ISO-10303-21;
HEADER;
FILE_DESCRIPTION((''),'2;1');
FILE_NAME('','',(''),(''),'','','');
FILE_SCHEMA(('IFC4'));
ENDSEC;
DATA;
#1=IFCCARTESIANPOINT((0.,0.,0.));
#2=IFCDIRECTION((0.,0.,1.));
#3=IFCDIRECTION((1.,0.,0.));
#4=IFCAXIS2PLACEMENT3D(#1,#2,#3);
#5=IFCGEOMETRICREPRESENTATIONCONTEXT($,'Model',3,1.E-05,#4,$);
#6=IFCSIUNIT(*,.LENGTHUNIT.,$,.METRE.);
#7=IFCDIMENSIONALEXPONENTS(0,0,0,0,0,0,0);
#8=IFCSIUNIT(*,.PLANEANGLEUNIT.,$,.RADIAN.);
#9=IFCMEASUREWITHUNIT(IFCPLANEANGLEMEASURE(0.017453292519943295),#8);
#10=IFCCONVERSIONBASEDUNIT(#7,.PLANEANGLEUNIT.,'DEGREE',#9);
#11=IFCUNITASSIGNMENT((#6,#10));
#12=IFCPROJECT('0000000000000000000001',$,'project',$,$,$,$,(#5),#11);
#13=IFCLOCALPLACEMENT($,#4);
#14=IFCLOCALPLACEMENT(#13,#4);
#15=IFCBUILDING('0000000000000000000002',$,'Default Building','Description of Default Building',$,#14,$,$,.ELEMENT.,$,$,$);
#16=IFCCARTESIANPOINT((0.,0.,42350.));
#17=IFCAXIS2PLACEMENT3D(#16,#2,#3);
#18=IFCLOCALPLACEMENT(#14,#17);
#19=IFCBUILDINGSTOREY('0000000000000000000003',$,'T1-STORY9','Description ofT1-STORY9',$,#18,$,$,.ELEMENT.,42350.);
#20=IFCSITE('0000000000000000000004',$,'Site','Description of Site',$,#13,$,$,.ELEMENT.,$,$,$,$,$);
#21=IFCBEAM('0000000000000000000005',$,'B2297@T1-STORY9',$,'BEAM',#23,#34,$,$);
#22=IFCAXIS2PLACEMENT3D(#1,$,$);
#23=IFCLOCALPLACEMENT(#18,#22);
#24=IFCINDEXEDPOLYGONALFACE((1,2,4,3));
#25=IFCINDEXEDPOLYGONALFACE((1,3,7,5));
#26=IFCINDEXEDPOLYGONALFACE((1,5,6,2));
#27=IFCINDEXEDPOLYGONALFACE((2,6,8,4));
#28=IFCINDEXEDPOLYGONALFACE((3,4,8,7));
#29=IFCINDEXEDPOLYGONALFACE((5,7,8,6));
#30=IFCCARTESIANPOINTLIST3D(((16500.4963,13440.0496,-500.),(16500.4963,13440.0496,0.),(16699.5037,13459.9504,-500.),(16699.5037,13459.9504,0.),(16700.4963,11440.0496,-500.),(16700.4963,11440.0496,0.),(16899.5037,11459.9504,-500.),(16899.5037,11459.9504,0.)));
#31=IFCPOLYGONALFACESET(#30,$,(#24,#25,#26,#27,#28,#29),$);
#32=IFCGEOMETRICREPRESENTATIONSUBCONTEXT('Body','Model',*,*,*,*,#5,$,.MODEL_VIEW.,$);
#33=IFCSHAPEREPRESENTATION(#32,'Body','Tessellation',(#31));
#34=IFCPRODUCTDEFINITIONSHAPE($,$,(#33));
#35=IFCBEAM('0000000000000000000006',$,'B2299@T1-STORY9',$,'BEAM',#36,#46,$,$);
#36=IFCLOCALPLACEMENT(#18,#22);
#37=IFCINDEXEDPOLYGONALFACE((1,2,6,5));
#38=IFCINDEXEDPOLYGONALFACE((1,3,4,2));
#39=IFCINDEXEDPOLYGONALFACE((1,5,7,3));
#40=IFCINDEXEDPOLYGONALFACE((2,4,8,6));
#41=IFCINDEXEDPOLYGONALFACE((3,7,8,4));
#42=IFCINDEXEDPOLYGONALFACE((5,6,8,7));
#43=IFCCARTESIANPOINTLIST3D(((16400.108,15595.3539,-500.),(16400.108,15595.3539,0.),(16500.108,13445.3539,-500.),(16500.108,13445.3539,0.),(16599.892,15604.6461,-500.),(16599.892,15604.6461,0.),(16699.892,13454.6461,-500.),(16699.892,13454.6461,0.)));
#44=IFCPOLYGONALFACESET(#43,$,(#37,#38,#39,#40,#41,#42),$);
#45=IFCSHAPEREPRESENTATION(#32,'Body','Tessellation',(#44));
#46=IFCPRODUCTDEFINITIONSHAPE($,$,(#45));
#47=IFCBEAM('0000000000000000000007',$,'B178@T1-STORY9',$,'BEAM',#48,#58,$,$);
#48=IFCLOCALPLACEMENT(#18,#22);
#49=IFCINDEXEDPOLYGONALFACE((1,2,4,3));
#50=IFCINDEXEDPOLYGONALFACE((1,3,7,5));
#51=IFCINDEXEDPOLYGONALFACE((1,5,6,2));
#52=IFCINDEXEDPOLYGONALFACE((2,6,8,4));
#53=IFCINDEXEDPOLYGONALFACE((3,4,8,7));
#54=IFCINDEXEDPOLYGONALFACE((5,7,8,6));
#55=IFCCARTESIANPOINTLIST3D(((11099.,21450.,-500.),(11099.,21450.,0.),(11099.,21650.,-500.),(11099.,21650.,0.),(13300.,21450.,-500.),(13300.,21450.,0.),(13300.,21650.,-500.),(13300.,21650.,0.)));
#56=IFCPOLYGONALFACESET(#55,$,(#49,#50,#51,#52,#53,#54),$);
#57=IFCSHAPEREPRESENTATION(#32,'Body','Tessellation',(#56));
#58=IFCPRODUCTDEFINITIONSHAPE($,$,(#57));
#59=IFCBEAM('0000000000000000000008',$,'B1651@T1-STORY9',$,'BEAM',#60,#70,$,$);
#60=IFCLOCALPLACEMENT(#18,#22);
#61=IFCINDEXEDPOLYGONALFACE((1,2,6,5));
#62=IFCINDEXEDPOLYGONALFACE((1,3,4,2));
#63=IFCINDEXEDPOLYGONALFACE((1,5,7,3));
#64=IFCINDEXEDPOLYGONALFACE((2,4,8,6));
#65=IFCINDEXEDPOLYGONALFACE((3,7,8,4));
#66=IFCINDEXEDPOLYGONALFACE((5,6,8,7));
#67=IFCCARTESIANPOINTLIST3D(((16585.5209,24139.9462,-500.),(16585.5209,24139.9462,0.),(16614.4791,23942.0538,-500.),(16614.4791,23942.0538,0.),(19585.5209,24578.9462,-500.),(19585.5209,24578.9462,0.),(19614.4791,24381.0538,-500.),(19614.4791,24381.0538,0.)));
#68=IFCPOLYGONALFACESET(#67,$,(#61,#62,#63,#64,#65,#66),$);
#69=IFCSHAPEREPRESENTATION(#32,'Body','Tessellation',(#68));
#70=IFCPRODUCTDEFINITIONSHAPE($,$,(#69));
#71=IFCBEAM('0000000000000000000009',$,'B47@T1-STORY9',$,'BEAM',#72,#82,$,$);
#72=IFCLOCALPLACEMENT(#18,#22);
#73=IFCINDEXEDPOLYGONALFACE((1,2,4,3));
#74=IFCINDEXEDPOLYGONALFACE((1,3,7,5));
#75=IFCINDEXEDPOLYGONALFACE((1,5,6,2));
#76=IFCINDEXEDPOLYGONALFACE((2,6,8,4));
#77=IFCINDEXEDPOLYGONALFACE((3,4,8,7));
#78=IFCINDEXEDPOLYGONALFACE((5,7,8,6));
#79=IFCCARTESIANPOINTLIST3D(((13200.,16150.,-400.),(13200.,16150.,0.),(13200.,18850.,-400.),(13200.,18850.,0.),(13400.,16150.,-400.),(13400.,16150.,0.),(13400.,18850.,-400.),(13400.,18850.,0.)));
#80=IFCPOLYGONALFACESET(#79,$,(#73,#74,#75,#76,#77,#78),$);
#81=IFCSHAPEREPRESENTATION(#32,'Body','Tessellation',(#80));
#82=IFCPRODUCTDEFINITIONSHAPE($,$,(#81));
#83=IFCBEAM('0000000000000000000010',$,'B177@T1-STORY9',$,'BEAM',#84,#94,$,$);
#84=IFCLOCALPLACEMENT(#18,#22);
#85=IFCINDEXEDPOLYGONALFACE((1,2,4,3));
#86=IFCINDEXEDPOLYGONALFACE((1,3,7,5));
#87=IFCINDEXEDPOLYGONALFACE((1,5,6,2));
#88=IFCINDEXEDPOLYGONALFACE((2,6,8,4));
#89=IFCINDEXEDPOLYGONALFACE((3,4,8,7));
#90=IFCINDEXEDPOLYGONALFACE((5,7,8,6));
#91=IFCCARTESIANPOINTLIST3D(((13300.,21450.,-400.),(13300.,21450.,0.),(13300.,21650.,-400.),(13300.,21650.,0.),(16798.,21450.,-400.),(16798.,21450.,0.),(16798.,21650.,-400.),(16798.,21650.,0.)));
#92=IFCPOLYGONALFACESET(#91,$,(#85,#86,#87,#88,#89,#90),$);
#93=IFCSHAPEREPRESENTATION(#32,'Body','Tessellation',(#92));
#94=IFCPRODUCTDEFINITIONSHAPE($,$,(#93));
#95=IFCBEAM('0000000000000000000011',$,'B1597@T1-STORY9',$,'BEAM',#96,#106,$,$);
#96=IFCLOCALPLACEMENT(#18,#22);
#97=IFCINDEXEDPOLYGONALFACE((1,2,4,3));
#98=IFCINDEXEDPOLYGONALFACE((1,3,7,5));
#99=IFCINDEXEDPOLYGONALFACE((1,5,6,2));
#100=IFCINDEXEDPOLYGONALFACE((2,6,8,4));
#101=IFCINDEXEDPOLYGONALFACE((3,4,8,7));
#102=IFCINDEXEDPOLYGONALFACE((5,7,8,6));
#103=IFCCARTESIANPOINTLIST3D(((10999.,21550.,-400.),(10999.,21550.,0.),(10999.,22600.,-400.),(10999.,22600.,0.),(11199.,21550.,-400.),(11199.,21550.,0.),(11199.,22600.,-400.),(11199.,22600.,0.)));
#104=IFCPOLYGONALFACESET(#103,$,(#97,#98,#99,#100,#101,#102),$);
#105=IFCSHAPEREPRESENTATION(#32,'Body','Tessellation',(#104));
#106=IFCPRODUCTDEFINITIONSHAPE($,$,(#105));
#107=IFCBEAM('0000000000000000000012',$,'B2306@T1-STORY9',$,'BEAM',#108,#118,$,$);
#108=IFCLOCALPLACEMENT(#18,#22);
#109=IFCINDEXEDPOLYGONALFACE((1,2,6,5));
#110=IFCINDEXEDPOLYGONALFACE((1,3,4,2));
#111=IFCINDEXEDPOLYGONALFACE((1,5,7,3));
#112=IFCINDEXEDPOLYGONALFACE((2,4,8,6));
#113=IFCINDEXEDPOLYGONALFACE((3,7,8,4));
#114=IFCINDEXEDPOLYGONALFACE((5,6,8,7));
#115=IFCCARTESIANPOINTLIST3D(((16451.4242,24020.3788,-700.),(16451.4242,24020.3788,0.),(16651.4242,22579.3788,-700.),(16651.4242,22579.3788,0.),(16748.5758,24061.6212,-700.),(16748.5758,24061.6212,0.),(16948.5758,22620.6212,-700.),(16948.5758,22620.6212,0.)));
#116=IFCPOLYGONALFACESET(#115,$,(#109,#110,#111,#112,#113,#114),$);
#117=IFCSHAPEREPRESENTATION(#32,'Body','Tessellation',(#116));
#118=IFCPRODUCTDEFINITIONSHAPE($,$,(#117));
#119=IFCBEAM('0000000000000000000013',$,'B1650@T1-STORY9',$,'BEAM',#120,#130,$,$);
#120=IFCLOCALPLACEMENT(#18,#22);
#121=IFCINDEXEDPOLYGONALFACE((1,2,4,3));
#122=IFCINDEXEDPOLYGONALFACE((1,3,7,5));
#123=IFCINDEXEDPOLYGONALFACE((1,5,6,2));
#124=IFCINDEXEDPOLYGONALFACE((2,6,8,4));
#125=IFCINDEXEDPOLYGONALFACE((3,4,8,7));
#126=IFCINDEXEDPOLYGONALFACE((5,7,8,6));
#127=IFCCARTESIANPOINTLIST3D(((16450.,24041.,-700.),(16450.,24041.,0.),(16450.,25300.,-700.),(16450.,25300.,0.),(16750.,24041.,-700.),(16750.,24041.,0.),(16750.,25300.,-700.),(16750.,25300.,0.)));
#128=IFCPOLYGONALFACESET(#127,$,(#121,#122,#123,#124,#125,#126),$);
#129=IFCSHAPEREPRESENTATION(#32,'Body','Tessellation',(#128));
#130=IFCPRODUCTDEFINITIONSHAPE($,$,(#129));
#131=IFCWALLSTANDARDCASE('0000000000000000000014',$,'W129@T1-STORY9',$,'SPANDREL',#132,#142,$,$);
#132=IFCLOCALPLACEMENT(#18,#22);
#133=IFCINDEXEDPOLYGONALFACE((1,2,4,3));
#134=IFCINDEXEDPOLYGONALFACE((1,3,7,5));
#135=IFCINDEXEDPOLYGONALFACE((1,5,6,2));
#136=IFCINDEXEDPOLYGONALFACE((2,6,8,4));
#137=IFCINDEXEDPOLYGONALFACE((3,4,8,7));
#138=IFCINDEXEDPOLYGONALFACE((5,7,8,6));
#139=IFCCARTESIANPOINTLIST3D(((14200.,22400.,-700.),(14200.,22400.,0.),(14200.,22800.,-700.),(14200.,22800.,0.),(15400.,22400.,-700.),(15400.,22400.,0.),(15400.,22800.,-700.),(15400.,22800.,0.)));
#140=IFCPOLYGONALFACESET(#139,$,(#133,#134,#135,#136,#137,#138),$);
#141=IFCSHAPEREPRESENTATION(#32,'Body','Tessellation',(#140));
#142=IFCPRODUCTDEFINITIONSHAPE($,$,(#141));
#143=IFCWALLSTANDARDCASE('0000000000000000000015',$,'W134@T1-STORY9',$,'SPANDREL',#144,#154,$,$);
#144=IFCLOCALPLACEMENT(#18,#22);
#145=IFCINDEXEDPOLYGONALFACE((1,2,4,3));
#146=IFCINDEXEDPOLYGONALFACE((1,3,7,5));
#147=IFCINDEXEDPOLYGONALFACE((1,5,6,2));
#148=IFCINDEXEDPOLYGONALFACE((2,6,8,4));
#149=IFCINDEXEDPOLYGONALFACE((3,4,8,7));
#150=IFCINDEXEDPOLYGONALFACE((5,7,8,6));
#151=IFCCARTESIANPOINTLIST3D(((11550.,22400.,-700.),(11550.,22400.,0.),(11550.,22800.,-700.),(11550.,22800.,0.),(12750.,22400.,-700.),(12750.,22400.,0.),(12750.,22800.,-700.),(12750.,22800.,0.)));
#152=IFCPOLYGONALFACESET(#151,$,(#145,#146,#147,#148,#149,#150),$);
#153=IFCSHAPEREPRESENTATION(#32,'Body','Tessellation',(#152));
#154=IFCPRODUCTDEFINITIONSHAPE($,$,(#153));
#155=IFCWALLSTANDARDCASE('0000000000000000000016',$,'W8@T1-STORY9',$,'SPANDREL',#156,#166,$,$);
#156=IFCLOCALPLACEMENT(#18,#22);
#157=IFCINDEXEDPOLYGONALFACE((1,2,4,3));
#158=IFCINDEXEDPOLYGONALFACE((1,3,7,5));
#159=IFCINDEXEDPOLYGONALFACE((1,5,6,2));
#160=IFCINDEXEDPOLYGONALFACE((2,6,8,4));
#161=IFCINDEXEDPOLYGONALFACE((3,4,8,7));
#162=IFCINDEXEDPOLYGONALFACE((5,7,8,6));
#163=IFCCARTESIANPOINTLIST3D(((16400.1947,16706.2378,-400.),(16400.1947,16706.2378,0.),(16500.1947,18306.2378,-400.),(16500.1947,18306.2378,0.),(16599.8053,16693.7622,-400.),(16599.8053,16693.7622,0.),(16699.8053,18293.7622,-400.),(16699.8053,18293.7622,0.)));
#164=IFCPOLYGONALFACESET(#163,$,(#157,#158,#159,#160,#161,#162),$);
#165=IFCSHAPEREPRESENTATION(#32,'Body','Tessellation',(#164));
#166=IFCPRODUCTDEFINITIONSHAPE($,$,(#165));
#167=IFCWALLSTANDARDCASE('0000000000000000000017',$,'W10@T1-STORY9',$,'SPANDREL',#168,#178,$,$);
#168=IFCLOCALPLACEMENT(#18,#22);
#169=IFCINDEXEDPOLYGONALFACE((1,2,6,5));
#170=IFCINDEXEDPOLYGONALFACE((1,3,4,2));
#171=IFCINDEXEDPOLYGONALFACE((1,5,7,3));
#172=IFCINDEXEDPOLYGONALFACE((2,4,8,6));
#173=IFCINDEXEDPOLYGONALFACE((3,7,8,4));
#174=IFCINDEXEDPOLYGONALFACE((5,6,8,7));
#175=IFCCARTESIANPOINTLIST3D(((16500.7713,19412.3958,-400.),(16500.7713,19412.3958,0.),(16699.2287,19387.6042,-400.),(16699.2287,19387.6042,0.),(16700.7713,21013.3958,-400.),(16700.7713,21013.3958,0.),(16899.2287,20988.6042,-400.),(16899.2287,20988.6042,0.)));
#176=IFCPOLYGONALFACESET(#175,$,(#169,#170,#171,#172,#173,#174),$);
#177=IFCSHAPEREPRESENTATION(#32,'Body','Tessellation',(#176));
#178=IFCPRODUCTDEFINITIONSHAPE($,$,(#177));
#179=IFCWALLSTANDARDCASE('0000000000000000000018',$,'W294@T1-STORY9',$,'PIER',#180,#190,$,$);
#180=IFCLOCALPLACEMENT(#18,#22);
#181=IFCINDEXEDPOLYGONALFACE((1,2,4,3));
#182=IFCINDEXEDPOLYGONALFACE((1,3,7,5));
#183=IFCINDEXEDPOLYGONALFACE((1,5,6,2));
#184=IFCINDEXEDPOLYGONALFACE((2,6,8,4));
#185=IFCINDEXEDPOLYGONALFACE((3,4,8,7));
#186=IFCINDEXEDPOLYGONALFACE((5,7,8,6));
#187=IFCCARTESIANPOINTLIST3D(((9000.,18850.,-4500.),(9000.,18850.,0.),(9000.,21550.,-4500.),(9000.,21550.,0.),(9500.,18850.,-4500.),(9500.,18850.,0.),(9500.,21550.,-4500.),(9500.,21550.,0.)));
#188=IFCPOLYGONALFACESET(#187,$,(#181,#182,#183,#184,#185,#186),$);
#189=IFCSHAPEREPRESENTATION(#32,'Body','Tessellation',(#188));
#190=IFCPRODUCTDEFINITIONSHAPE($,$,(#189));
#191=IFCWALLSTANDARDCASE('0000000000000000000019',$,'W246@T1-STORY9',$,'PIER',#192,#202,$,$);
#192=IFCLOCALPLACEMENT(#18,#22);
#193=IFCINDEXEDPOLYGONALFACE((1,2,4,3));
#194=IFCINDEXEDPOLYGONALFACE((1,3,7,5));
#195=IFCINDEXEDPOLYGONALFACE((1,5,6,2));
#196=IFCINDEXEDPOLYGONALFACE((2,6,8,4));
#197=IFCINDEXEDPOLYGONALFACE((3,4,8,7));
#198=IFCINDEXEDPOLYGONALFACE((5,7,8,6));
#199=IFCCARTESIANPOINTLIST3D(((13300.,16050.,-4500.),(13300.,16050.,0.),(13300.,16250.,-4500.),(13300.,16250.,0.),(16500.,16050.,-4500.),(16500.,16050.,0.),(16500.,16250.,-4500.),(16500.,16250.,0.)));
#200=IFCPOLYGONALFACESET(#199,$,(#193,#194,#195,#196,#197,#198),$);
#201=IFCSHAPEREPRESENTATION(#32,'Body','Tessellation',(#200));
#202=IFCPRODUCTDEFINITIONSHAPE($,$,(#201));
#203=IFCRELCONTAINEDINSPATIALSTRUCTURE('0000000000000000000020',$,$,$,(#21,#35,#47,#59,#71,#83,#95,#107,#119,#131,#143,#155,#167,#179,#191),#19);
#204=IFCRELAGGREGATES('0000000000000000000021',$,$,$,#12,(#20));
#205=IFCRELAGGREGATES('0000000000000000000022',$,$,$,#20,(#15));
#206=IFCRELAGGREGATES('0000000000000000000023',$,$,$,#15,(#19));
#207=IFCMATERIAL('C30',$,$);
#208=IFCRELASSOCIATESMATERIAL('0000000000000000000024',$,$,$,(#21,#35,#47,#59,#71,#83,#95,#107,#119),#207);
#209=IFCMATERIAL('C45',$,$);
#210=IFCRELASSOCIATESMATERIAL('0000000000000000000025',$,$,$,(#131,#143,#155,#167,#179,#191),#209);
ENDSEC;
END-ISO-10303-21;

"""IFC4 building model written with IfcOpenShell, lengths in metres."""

from ifc_helpers import new_model, entity, si_unit, converted_unit, frame, origin_with_axes, place, context, subcontext, project, spatial, indexed_curve, rectangle, outline, extrude, material, element, save


model = new_model("IFC4")

# Units and contexts
model_context = context("Model", 3, precision=1e-05, world=origin_with_axes())
body_context = subcontext(model_context, "Body", "Model", "MODEL_VIEW")
ifc_project = project(units=[si_unit("LENGTHUNIT", "METRE"), converted_unit("PLANEANGLEUNIT", "DEGREE", entity("IfcPlaneAngleMeasure", 0.017453292519943295), si_unit("PLANEANGLEUNIT", "RADIAN"), dimensions=[0, 0, 0, 0, 0, 0, 0])], contexts=[model_context])

# Site, building, storey
site_placement = place(None, origin_with_axes())
site = spatial("IfcSite", under=ifc_project, at=site_placement, Name="Site", Description="Description of Site", CompositionType="ELEMENT")
building_placement = place(site_placement, origin_with_axes())
building = spatial("IfcBuilding", under=site, at=building_placement, Name="Default Building", Description="Description of Default Building", CompositionType="ELEMENT")
storey_placement = place(building_placement, frame((0.0, 0.0, 42350.0), z_axis=(0.0, 0.0, 1.0), x_axis=(1.0, 0.0, 0.0)))
storey = spatial("IfcBuildingStorey", under=building, at=storey_placement, Name="T1-STORY9", Description="Description ofT1-STORY9", CompositionType="ELEMENT", Elevation=42350.0)

# Beams
ifc_material_1 = material(Name="C30")
beam_1_placement = place(storey_placement, frame((16600.0, 13450.0, -250.0), z_axis=(0.099504, -0.995037, 0.0), x_axis=(0.995037, 0.099504, 0.0)))
element("IfcBeam", 1, at=beam_1_placement, inside=storey, material=ifc_material_1, Name="B2297@T1-STORY9", ObjectType="BEAM", context=body_context, shape_type="SweptSolid", body=[
    extrude(rectangle(XDim=200.0, YDim=500.0), origin_with_axes(), (0.0, 0.0, 1.0), 2009.9751),
])
beam_2_placement = place(storey_placement, frame((16500.0, 15600.0, -250.0), z_axis=(0.046461, -0.99892, 0.0), x_axis=(0.99892, 0.046461, 0.0)))
element("IfcBeam", 2, at=beam_2_placement, inside=storey, material=ifc_material_1, Name="B2299@T1-STORY9", ObjectType="BEAM", context=body_context, shape_type="SweptSolid", body=[
    extrude(rectangle(XDim=200.0, YDim=500.0), origin_with_axes(), (0.0, 0.0, 1.0), 2152.3243),
])
beam_3_placement = place(storey_placement, frame((11099.0, 21550.0, -250.0), z_axis=(1.0, 0.0, 0.0), x_axis=(0.0, 1.0, 0.0)))
element("IfcBeam", 3, at=beam_3_placement, inside=storey, material=ifc_material_1, Name="B178@T1-STORY9", ObjectType="BEAM", context=body_context, shape_type="SweptSolid", body=[
    extrude(rectangle(XDim=200.0, YDim=500.0), origin_with_axes(), (0.0, 0.0, 1.0), 2201.0),
])
beam_4_placement = place(storey_placement, frame((16600.0, 24041.0, -250.0), z_axis=(0.989462, 0.144791, 0.0), x_axis=(-0.144791, 0.989462, 0.0)))
element("IfcBeam", 4, at=beam_4_placement, inside=storey, material=ifc_material_1, Name="B1651@T1-STORY9", ObjectType="BEAM", context=body_context, shape_type="SweptSolid", body=[
    extrude(rectangle(XDim=200.0, YDim=500.0), origin_with_axes(), (0.0, 0.0, 1.0), 3031.95),
])
beam_5_placement = place(storey_placement, frame((13300.0, 16150.0, -200.0), z_axis=(0.0, 1.0, 0.0), x_axis=(-1.0, 0.0, 0.0)))
element("IfcBeam", 5, at=beam_5_placement, inside=storey, material=ifc_material_1, Name="B47@T1-STORY9", ObjectType="BEAM", context=body_context, shape_type="SweptSolid", body=[
    extrude(rectangle(XDim=200.0, YDim=400.0), origin_with_axes(), (0.0, 0.0, 1.0), 2700.0),
])
beam_6_placement = place(storey_placement, frame((13300.0, 21550.0, -200.0), z_axis=(1.0, 0.0, 0.0), x_axis=(0.0, 1.0, 0.0)))
element("IfcBeam", 6, at=beam_6_placement, inside=storey, material=ifc_material_1, Name="B177@T1-STORY9", ObjectType="BEAM", context=body_context, shape_type="SweptSolid", body=[
    extrude(rectangle(XDim=200.0, YDim=400.0), origin_with_axes(), (0.0, 0.0, 1.0), 3498.0),
])
beam_7_placement = place(storey_placement, frame((11099.0, 21550.0, -200.0), z_axis=(0.0, 1.0, 0.0), x_axis=(-1.0, 0.0, 0.0)))
element("IfcBeam", 7, at=beam_7_placement, inside=storey, material=ifc_material_1, Name="B1597@T1-STORY9", ObjectType="BEAM", context=body_context, shape_type="SweptSolid", body=[
    extrude(rectangle(XDim=200.0, YDim=400.0), origin_with_axes(), (0.0, 0.0, 1.0), 1050.0),
])
beam_8_placement = place(storey_placement, frame((16600.0, 24041.0, -350.0), z_axis=(0.137475, -0.990505, 0.0), x_axis=(0.990505, 0.137475, 0.0)))
element("IfcBeam", 8, at=beam_8_placement, inside=storey, material=ifc_material_1, Name="B2306@T1-STORY9", ObjectType="BEAM", context=body_context, shape_type="SweptSolid", body=[
    extrude(rectangle(XDim=300.0, YDim=700.0), origin_with_axes(), (0.0, 0.0, 1.0), 1454.813),
])
beam_9_placement = place(storey_placement, frame((16600.0, 24041.0, -350.0), z_axis=(0.0, 1.0, 0.0), x_axis=(-1.0, 0.0, 0.0)))
element("IfcBeam", 9, at=beam_9_placement, inside=storey, material=ifc_material_1, Name="B1650@T1-STORY9", ObjectType="BEAM", context=body_context, shape_type="SweptSolid", body=[
    extrude(rectangle(XDim=300.0, YDim=700.0), origin_with_axes(), (0.0, 0.0, 1.0), 1259.0),
])
ifc_material_2 = material(Name="C45")

# Walls
for number, where, z_axis, x_axis, name in (
    (10, (14200.0, 22600.0, -700.0), (0.0, 0.0, 1.0), (1.0, 0.0, 0.0), "W129@T1-STORY9"),
    (11, (11550.0, 22600.0, -700.0), (0.0, 0.0, 1.0), (1.0, 0.0, 0.0), "W134@T1-STORY9"),
):
    element("IfcWallStandardCase", number, at=place(storey_placement, frame(where, z_axis=z_axis, x_axis=x_axis)), inside=storey, material=ifc_material_2, Name=name, ObjectType="SPANDREL", context=body_context, shape_type="SweptSolid", body=[
        extrude(outline(indexed_curve([(0.0, -200.0), (0.0, 200.0), (1200.0, 200.0), (1200.0, -200.0), (0.0, -200.0)], self_intersect=False)), origin_with_axes(), (0.0, 0.0, 1.0), 700.0),
    ])
wall_1_placement = place(storey_placement, frame((16500.0, 16700.0, -400.0), z_axis=(0.0, 0.0, 1.0), x_axis=(0.062378, 0.998053, 0.0)))
element("IfcWallStandardCase", 12, at=wall_1_placement, inside=storey, material=ifc_material_2, Name="W8@T1-STORY9", ObjectType="SPANDREL", context=body_context, shape_type="SweptSolid", body=[
    extrude(outline(indexed_curve([(0.0, -100.0), (0.0, 100.0), (1603.122, 100.0), (1603.122, -100.0), (0.0, -100.0)], self_intersect=False)), origin_with_axes(), (0.0, 0.0, 1.0), 400.0),
])
wall_2_placement = place(storey_placement, frame((16600.0, 19400.0, -400.0), z_axis=(0.0, 0.0, 1.0), x_axis=(0.123958, 0.992287, 0.0)))
element("IfcWallStandardCase", 13, at=wall_2_placement, inside=storey, material=ifc_material_2, Name="W10@T1-STORY9", ObjectType="SPANDREL", context=body_context, shape_type="SweptSolid", body=[
    extrude(outline(indexed_curve([(0.0, -100.0), (0.0, 100.0), (1613.4438, 100.0), (1613.4438, -100.0), (0.0, -100.0)], self_intersect=False)), origin_with_axes(), (0.0, 0.0, 1.0), 400.0),
])
wall_3_placement = place(storey_placement, frame((9250.0, 18850.0, -4500.0), z_axis=(0.0, 0.0, 1.0), x_axis=(0.0, 1.0, 0.0)))
element("IfcWallStandardCase", 14, at=wall_3_placement, inside=storey, material=ifc_material_2, Name="W294@T1-STORY9", ObjectType="PIER", context=body_context, shape_type="SweptSolid", body=[
    extrude(outline(indexed_curve([(0.0, -250.0), (0.0, 250.0), (2700.0, 250.0), (2700.0, -250.0), (0.0, -250.0)], self_intersect=False)), origin_with_axes(), (0.0, 0.0, 1.0), 4500.0),
])
wall_4_placement = place(storey_placement, frame((13300.0, 16150.0, -4500.0), z_axis=(0.0, 0.0, 1.0), x_axis=(1.0, 0.0, 0.0)))
element("IfcWallStandardCase", 15, at=wall_4_placement, inside=storey, material=ifc_material_2, Name="W246@T1-STORY9", ObjectType="PIER", context=body_context, shape_type="SweptSolid", body=[
    extrude(outline(indexed_curve([(0.0, -100.0), (0.0, 100.0), (3200.0, 100.0), (3200.0, -100.0), (0.0, -100.0)], self_intersect=False)), origin_with_axes(), (0.0, 0.0, 1.0), 4500.0),
])

save(model, "model.ifc")
